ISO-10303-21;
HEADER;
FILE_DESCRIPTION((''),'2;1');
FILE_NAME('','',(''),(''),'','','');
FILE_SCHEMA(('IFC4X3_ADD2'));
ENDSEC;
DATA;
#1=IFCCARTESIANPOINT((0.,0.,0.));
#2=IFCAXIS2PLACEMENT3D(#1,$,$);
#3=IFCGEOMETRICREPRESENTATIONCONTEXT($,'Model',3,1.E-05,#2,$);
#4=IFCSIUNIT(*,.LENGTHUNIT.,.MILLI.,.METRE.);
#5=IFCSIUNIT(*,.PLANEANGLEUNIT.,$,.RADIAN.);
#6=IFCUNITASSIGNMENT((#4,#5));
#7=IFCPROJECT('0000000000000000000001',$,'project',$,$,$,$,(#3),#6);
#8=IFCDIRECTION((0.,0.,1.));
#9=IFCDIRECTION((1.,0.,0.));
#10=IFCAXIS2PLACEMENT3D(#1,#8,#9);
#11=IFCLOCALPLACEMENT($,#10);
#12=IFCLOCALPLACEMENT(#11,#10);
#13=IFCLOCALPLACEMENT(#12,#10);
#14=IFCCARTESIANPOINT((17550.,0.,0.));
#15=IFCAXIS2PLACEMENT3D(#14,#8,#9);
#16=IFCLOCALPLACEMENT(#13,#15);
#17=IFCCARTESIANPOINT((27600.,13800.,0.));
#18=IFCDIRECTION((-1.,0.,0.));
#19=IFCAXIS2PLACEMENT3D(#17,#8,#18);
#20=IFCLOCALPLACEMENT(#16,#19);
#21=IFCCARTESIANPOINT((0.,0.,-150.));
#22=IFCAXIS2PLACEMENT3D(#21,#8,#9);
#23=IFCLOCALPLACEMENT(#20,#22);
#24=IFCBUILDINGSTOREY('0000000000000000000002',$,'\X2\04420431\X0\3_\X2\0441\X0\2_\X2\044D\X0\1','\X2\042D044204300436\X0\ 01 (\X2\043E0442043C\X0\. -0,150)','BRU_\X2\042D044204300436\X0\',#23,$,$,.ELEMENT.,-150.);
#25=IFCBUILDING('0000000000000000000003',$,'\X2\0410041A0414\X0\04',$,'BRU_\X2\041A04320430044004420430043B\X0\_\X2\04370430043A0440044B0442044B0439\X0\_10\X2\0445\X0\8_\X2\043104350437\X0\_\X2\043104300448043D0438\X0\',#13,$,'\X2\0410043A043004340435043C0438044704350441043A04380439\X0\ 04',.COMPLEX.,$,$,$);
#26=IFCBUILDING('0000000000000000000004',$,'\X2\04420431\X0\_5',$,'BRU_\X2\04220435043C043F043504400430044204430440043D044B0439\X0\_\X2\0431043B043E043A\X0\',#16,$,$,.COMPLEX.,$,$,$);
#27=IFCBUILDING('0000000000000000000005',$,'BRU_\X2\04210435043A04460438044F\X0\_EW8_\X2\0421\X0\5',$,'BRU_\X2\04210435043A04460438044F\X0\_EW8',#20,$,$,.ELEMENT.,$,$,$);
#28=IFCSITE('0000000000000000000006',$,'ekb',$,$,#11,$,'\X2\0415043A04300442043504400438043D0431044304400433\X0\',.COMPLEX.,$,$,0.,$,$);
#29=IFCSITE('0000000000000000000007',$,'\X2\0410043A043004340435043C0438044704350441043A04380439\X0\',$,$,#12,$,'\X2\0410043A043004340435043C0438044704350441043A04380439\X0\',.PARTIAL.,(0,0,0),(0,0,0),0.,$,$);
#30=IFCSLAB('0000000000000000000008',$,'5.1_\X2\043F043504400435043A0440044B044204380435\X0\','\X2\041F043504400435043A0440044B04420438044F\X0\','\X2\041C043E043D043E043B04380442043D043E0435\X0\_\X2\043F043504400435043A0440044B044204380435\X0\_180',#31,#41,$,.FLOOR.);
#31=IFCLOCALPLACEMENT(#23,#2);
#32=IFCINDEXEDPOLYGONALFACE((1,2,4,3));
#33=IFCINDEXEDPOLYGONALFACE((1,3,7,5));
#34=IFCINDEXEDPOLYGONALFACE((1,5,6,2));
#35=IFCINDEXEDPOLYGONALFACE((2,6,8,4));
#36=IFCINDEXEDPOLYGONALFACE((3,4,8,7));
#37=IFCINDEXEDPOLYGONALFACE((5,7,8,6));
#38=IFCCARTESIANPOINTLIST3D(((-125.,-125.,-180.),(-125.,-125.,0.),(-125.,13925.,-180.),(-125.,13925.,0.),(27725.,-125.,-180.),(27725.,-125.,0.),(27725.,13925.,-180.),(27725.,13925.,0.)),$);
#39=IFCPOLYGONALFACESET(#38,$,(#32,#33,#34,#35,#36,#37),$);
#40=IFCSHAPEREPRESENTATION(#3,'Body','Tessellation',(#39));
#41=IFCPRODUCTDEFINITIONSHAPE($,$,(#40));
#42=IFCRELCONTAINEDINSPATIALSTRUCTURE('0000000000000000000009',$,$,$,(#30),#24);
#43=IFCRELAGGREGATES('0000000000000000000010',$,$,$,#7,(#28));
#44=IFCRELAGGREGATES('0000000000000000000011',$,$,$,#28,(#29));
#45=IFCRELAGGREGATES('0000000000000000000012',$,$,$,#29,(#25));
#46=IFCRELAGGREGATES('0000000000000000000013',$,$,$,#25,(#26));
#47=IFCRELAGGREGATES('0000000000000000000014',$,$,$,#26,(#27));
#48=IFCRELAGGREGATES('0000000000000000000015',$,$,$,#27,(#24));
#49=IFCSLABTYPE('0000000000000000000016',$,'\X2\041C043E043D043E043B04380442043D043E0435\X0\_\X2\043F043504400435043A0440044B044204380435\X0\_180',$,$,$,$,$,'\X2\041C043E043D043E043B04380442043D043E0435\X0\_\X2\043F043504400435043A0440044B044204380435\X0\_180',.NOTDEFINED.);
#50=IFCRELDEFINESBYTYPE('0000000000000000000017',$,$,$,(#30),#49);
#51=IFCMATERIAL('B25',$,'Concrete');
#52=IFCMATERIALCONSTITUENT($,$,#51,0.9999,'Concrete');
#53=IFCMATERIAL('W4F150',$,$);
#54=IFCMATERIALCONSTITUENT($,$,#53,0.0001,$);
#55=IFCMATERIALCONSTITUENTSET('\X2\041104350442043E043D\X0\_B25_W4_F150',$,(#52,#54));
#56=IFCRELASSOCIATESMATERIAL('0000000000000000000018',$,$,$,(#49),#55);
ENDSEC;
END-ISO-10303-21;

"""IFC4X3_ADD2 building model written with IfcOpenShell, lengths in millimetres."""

from ifc_helpers import new_model, si_unit, frame, origin, origin_with_axes, place, context, project, spatial, polyline, outline, extrude, material, constituent, constituent_set, type_object, element, save


model = new_model("IFC4X3_ADD2")

# Units and contexts
model_context = context("Model", 3, precision=1e-05, world=origin())
ifc_project = project(units=[si_unit("LENGTHUNIT", "METRE", prefix="MILLI"), si_unit("PLANEANGLEUNIT", "RADIAN")], contexts=[model_context])

# Sites, buildings, storey
site_1_placement = place(None, origin_with_axes())
site_1 = spatial("IfcSite", under=ifc_project, at=site_1_placement, Name="ekb", LongName="Екатеринбург", CompositionType="COMPLEX", RefElevation=0.0)
site_2_placement = place(site_1_placement, origin_with_axes())
site_2 = spatial("IfcSite", under=site_1, at=site_2_placement, Name="Академический", LongName="Академический", CompositionType="PARTIAL", RefLatitude=(0, 0, 0), RefLongitude=(0, 0, 0), RefElevation=0.0)
building_1_placement = place(site_2_placement, origin_with_axes())
building_1 = spatial("IfcBuilding", under=site_2, at=building_1_placement, Name="АКД04", ObjectType="BRU_Квартал_закрытый_10х8_без_башни", LongName="Академический 04", CompositionType="COMPLEX")
building_2_placement = place(building_1_placement, frame((17550.0, 0.0, 0.0), z_axis=(0.0, 0.0, 1.0), x_axis=(1.0, 0.0, 0.0)))
building_2 = spatial("IfcBuilding", under=building_1, at=building_2_placement, Name="тб_5", ObjectType="BRU_Температурный_блок", CompositionType="COMPLEX")
building_3_placement = place(building_2_placement, frame((27600.0, 13800.0, 0.0), z_axis=(0.0, 0.0, 1.0), x_axis=(-1.0, 0.0, 0.0)))
building_3 = spatial("IfcBuilding", under=building_2, at=building_3_placement, Name="BRU_Секция_EW8_С5", ObjectType="BRU_Секция_EW8", CompositionType="ELEMENT")
storey_placement = place(building_3_placement, frame((0.0, 0.0, -150.0), z_axis=(0.0, 0.0, 1.0), x_axis=(1.0, 0.0, 0.0)))
storey = spatial("IfcBuildingStorey", under=building_3, at=storey_placement, Name="тб3_с2_э1", Description="Этаж 01 (отм. -0,150)", ObjectType="BRU_Этаж", CompositionType="ELEMENT", Elevation=-150.0)

# Shared definitions
ifc_material_1 = material(Name="B25", Category="Concrete")
ifc_material_2 = material(Name="W4F150")

# Slab
ifc_constituent_1 = constituent(ifc_material_1, Category="Concrete", fraction=0.9999)
ifc_constituent_2 = constituent(ifc_material_2, fraction=0.0001)
ifc_constituent_set_1 = constituent_set(constituents=[ifc_constituent_1, ifc_constituent_2], Name="Бетон_B25_W4_F150")
slab_type = type_object("IfcSlabType", Name="Монолитное_перекрытие_180", ElementType="Монолитное_перекрытие_180", PredefinedType="NOTDEFINED", material=ifc_constituent_set_1)
slab_placement = place(storey_placement, frame((0.0, 0.0, -180.0), z_axis=(0.0, 0.0, 1.0), x_axis=(1.0, 0.0, 0.0)))
element("IfcSlab", 1, at=slab_placement, inside=storey, type_object=slab_type, Name="5.1_перекрытие", Description="Перекрытия", ObjectType="Монолитное_перекрытие_180", PredefinedType="FLOOR", context=model_context, shape_type="SweptSolid", body=[
    extrude(outline(polyline([(27725.0, 13925.0), (-125.0, 13925.0), (-125.0, -125.0), (27725.0, -125.0), (27725.0, 13925.0)])), origin_with_axes(), (0.0, 0.0, 1.0), 180.0),
])

save(model, "model.ifc")
